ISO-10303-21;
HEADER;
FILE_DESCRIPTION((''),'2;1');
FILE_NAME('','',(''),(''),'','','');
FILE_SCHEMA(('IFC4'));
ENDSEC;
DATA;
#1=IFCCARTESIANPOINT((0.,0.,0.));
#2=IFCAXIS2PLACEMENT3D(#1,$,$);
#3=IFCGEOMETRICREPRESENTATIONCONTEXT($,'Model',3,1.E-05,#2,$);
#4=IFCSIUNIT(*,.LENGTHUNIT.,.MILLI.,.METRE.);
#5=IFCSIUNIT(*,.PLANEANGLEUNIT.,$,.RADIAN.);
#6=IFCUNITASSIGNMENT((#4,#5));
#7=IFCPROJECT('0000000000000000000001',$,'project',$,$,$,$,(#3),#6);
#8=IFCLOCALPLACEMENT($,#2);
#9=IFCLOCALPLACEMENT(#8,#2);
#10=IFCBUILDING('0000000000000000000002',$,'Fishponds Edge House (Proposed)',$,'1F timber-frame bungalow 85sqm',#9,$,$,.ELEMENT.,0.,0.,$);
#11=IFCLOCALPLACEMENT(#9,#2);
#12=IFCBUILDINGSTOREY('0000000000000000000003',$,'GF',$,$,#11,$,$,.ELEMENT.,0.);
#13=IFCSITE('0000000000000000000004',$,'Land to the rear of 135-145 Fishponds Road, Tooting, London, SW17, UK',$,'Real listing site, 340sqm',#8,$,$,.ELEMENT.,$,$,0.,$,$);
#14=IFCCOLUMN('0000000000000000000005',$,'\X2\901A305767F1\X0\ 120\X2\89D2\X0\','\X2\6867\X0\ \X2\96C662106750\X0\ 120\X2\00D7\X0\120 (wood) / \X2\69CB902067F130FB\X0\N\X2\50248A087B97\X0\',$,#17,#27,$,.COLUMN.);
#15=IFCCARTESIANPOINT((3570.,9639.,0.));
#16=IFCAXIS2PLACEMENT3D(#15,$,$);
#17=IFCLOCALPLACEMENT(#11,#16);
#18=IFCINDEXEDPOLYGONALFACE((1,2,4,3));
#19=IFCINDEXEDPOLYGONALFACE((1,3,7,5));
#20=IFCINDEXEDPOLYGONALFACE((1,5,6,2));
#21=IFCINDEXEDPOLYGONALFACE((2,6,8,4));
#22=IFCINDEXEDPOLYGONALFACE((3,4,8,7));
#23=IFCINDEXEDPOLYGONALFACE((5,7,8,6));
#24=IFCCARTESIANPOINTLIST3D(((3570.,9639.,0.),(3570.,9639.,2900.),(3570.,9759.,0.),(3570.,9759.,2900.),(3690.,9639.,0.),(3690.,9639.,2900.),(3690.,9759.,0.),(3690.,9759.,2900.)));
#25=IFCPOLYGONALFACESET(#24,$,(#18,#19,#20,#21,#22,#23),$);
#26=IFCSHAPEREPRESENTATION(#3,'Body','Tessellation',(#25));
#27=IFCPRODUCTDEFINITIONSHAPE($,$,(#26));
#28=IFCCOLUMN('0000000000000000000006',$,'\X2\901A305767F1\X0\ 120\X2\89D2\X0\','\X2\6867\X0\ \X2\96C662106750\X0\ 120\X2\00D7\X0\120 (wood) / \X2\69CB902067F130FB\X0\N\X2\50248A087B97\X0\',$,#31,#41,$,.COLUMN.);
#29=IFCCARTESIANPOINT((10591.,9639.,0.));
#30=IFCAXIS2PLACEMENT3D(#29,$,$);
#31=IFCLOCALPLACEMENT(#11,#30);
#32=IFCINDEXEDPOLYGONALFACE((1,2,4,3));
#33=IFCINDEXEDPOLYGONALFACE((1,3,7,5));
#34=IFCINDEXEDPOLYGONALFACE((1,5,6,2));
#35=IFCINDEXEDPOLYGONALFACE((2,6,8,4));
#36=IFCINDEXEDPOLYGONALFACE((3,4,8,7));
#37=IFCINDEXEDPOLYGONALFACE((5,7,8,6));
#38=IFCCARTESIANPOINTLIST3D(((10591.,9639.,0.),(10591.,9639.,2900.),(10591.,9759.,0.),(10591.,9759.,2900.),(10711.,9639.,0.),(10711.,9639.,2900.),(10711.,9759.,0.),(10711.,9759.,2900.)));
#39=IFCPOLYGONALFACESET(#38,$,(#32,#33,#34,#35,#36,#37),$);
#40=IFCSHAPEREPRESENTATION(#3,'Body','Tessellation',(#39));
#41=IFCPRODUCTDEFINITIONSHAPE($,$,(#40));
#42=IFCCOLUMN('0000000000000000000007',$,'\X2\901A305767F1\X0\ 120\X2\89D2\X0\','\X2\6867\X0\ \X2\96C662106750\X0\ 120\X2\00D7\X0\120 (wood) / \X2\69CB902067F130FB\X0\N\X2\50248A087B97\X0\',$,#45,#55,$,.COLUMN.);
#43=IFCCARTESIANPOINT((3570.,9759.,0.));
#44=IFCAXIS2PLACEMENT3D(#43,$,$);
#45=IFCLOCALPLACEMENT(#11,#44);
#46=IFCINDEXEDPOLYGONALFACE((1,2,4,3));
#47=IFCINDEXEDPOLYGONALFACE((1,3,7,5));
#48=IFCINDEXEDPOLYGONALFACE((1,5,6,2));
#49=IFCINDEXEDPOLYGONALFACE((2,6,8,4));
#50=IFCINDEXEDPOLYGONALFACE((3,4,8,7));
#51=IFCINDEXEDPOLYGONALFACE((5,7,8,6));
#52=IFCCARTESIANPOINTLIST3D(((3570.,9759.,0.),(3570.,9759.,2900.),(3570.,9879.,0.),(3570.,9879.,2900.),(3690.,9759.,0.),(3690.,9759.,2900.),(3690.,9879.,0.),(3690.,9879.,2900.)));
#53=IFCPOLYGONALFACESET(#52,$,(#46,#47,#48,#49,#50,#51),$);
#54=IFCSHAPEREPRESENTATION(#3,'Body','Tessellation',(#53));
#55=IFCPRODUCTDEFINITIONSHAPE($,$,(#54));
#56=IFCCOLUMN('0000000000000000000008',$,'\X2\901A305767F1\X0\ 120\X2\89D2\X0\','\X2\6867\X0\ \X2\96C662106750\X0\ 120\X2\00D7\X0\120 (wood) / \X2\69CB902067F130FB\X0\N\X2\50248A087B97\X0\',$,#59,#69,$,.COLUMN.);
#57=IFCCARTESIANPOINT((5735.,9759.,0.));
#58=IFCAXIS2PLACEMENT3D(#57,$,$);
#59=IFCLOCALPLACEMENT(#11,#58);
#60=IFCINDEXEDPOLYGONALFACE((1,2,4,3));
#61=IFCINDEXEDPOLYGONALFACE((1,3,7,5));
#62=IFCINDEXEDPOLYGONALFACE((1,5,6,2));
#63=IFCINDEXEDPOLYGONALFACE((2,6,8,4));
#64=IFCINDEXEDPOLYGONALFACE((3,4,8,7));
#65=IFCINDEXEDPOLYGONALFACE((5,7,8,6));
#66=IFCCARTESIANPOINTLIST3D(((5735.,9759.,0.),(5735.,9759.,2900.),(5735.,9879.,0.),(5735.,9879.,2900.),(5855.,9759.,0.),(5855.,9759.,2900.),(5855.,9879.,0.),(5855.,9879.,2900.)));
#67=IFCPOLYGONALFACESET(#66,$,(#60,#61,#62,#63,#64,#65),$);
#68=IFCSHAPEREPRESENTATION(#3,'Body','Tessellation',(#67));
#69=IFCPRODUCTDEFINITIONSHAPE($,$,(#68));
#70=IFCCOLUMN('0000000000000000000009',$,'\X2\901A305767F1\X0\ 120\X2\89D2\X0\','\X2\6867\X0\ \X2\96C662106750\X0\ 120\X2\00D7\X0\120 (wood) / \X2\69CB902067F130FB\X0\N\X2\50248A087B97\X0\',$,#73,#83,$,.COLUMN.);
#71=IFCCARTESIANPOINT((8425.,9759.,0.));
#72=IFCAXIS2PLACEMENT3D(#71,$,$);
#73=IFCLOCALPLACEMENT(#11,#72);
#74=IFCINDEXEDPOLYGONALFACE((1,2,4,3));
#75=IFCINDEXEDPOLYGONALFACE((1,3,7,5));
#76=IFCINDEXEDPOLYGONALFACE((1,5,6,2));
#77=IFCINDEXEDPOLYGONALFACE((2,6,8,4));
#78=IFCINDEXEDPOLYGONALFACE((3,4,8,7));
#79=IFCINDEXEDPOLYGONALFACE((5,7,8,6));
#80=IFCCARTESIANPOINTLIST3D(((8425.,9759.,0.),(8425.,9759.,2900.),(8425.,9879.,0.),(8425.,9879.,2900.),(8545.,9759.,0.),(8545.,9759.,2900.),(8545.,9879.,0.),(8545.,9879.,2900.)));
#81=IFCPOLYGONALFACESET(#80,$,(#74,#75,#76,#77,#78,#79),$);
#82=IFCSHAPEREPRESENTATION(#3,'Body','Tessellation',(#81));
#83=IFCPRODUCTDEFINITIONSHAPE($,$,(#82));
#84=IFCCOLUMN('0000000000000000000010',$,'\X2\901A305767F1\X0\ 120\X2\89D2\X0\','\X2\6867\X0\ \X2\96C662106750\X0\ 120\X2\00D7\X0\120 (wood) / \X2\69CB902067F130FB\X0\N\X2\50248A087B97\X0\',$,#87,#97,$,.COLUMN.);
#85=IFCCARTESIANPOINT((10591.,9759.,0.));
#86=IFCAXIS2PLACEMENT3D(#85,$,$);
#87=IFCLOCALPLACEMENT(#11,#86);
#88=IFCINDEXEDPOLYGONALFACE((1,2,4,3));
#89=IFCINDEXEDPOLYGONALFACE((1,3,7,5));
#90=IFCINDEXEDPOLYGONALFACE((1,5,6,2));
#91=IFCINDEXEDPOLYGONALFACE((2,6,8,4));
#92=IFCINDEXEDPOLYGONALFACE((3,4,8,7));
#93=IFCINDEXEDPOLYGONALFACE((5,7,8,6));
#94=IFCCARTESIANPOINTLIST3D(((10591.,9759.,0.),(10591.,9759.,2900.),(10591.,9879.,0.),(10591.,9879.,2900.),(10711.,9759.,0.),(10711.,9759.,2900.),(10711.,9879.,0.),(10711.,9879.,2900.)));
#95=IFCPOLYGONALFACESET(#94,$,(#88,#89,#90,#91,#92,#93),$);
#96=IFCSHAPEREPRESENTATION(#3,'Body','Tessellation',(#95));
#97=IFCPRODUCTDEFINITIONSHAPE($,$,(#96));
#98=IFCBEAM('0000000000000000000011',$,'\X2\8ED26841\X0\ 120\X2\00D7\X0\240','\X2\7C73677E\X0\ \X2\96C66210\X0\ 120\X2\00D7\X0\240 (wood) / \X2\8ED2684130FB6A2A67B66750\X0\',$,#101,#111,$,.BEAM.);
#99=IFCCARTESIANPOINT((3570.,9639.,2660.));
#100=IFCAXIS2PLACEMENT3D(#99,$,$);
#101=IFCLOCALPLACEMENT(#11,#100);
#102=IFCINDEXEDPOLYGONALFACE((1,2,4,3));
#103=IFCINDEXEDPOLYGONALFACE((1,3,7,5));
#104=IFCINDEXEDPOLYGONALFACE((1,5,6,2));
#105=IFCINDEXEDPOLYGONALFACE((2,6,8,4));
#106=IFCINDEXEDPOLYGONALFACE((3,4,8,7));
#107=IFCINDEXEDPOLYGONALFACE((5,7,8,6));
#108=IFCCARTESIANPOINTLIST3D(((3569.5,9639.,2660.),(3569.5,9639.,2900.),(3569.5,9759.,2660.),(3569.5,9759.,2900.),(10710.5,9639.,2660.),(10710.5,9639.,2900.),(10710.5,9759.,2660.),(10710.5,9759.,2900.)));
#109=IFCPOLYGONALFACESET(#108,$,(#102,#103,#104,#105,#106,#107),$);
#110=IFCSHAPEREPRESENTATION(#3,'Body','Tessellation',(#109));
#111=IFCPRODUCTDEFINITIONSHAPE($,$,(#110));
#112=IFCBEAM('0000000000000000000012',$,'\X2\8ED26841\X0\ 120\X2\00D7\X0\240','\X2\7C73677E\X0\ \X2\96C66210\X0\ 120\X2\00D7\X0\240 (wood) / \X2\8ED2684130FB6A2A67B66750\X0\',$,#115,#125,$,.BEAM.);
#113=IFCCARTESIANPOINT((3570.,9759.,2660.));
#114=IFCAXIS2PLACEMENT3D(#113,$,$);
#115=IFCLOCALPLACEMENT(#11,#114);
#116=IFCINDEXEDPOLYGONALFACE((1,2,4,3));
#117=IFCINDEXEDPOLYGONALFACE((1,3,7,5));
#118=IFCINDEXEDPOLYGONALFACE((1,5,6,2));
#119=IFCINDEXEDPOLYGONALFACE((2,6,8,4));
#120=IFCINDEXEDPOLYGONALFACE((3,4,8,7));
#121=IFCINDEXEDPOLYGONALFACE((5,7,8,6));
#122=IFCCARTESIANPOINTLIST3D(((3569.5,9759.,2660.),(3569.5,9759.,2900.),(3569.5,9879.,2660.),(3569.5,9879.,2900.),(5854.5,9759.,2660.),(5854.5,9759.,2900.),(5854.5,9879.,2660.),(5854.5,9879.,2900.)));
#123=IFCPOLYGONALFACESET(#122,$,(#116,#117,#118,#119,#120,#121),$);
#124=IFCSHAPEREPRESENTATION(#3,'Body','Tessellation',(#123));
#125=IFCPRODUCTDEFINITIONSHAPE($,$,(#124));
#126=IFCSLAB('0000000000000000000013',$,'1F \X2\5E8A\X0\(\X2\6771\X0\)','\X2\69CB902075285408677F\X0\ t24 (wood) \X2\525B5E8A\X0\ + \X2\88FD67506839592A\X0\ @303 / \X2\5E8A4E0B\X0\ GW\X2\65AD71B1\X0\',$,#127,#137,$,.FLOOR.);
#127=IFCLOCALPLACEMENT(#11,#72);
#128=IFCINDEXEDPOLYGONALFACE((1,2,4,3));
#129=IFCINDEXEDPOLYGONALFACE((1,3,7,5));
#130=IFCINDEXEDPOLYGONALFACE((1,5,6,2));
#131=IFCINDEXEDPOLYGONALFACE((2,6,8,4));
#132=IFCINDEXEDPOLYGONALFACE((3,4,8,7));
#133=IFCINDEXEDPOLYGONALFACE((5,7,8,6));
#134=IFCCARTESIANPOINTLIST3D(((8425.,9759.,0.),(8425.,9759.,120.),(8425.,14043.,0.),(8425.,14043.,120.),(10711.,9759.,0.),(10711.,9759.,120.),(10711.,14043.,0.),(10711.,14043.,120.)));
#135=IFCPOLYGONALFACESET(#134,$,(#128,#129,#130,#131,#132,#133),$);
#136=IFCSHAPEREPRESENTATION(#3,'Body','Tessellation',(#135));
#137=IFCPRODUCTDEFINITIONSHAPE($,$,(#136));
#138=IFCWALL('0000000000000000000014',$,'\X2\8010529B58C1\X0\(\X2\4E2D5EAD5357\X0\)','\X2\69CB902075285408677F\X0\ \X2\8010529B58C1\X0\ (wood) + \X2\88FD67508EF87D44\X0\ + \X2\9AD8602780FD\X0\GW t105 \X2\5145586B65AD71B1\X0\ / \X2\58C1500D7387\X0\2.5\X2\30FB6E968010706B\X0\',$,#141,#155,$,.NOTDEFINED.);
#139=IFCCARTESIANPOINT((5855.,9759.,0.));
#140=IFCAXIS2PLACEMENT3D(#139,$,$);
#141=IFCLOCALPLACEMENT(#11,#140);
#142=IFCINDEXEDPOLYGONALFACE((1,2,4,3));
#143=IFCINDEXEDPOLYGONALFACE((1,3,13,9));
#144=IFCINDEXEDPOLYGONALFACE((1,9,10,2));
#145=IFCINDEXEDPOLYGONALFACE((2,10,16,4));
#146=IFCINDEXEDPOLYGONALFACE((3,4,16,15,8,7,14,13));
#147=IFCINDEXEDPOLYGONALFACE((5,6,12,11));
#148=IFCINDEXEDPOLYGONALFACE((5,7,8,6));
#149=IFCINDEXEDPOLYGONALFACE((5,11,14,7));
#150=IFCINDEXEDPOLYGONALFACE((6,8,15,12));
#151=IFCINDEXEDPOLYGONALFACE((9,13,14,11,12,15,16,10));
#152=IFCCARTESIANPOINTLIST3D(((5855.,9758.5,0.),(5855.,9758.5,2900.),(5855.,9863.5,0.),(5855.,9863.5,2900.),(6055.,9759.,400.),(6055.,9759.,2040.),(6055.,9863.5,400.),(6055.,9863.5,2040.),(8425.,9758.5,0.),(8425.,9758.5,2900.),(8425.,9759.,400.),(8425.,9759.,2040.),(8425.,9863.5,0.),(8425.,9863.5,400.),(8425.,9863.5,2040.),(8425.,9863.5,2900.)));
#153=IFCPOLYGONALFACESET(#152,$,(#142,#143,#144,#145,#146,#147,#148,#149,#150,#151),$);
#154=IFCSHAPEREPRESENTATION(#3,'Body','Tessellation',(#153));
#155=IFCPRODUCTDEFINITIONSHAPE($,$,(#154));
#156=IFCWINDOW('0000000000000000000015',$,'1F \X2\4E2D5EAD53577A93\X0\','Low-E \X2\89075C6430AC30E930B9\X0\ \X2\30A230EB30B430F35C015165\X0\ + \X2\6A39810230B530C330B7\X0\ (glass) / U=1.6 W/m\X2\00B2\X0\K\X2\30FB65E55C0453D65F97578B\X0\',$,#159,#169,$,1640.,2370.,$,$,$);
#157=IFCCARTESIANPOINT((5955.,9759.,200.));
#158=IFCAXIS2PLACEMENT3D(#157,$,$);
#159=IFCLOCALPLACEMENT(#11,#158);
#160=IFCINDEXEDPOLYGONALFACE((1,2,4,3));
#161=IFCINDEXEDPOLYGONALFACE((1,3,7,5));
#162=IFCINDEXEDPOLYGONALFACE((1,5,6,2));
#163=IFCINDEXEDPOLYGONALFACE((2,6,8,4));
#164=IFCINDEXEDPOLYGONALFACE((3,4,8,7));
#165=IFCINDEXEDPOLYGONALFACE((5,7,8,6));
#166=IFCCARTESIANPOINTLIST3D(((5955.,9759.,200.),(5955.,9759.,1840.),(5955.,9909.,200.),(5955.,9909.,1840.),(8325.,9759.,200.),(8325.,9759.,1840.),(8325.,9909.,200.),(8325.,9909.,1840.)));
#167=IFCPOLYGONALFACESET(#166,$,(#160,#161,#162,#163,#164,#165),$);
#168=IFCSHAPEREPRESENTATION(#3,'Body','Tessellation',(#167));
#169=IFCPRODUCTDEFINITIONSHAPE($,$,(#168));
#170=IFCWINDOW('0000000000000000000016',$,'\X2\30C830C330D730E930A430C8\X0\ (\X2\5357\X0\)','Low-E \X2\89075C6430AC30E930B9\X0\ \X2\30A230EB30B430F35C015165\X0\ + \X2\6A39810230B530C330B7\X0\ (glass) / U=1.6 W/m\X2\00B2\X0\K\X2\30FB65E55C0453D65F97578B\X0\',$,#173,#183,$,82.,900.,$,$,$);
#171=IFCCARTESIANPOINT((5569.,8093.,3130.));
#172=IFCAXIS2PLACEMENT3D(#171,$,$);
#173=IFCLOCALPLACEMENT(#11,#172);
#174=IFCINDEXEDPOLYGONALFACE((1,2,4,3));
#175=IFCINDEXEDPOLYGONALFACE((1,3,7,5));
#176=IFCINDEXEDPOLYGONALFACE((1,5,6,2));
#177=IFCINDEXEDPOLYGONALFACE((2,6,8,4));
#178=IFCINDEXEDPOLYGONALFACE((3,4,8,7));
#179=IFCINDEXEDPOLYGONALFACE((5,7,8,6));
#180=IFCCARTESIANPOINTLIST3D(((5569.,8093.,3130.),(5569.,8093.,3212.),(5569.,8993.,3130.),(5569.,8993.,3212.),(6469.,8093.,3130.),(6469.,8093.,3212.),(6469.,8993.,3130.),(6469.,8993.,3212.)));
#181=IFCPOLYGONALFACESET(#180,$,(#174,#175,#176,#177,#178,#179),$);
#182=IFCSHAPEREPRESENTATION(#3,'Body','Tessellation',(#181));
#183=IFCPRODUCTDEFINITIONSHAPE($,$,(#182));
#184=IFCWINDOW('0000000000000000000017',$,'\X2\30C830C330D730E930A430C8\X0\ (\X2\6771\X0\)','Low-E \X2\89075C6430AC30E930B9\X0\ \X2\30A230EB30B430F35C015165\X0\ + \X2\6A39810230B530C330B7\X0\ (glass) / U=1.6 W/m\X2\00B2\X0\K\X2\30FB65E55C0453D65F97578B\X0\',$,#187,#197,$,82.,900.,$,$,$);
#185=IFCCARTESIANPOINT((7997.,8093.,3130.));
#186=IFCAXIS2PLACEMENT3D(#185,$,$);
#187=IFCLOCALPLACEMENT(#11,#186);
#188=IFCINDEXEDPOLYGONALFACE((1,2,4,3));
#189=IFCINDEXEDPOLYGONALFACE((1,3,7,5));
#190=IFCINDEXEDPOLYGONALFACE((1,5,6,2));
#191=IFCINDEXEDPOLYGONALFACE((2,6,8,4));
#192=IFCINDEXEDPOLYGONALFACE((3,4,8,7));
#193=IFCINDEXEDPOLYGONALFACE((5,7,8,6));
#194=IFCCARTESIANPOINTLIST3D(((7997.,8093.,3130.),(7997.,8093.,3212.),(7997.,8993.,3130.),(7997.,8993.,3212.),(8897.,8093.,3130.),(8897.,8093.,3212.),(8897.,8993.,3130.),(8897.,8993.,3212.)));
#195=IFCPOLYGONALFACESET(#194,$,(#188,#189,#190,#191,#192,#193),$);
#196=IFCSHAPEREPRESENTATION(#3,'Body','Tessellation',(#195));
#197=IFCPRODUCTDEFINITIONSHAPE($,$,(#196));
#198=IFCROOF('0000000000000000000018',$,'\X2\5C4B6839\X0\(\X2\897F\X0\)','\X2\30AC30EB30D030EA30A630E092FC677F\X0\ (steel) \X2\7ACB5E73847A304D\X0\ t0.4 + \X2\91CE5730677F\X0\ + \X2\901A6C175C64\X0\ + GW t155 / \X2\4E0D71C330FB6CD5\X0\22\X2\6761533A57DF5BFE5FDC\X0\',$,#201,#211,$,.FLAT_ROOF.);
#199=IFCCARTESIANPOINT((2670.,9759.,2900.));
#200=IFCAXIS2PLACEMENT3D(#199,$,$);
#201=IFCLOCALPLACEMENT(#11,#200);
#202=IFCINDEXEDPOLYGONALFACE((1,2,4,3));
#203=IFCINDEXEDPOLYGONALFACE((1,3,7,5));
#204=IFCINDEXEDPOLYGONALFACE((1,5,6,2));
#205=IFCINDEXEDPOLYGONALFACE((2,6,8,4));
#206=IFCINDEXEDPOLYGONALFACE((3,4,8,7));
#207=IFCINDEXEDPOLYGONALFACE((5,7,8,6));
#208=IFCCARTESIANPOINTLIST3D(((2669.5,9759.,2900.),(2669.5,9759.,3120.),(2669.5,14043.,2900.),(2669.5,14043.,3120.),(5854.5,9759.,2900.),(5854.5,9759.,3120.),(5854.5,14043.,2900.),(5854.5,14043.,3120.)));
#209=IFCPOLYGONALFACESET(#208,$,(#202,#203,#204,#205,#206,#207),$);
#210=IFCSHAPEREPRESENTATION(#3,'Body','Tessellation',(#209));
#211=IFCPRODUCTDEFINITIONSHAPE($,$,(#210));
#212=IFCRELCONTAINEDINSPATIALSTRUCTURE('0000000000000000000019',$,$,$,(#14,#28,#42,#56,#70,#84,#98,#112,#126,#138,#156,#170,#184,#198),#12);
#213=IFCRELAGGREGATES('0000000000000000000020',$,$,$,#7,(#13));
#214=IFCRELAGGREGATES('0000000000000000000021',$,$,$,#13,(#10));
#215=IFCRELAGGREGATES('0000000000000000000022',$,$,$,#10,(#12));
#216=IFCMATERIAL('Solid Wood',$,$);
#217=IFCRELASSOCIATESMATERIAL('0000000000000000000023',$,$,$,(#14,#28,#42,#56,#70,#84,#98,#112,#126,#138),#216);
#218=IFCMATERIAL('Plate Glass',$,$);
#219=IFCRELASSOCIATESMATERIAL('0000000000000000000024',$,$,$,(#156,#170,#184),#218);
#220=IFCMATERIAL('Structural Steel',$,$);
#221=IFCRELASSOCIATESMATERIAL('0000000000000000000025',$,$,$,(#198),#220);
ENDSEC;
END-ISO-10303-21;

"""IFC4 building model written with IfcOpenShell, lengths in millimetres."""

from ifc_helpers import new_model, si_unit, frame, frame_2d, origin, place, context, project, spatial, rectangle, extrude, material, element, fill, save


model = new_model("IFC4")

# Units and contexts
model_context = context("Model", 3, precision=1e-05, world=origin())
ifc_project = project(units=[si_unit("LENGTHUNIT", "METRE", prefix="MILLI"), si_unit("PLANEANGLEUNIT", "RADIAN")], contexts=[model_context])

# Site, building, storey
site_placement = place(None, origin())
site = spatial("IfcSite", under=ifc_project, at=site_placement, Name="Land to the rear of 135-145 Fishponds Road, Tooting, London, SW17, UK", ObjectType="Real listing site, 340sqm", CompositionType="ELEMENT", RefElevation=0.0)
building_placement = place(site_placement, origin())
building = spatial("IfcBuilding", under=site, at=building_placement, Name="Fishponds Edge House (Proposed)", ObjectType="1F timber-frame bungalow 85sqm", CompositionType="ELEMENT", ElevationOfRefHeight=0.0, ElevationOfTerrain=0.0)
storey_placement = place(building_placement, origin())
storey = spatial("IfcBuildingStorey", under=building, at=storey_placement, Name="GF", CompositionType="ELEMENT", Elevation=0.0)

# Columns
ifc_material_1 = material(Name="Solid Wood")
column_1_placement = place(storey_placement, frame((3570.0, 9639.0, 0.0)))
element("IfcColumn", 1, at=column_1_placement, inside=storey, material=ifc_material_1, Name="通し柱 120角", Description="桧 集成材 120×120 (wood) / 構造柱・N値計算", PredefinedType="COLUMN", context=model_context, shape_type="SweptSolid", body=[
    extrude(rectangle(XDim=120.0, YDim=120.0, at=frame_2d((60.0, 60.0))), frame((3570.0, 9639.0, 0.0)), (0.0, 0.0, 1.0), 2900.0),
])
column_2_placement = place(storey_placement, frame((10591.0, 9639.0, 0.0)))
element("IfcColumn", 2, at=column_2_placement, inside=storey, material=ifc_material_1, Name="通し柱 120角", Description="桧 集成材 120×120 (wood) / 構造柱・N値計算", PredefinedType="COLUMN", context=model_context, shape_type="SweptSolid", body=[
    extrude(rectangle(XDim=120.0, YDim=120.0, at=frame_2d((60.0, 60.0))), frame((10591.0, 9639.0, 0.0)), (0.0, 0.0, 1.0), 2900.0),
])
column_3_placement = place(storey_placement, frame((3570.0, 9759.0, 0.0)))
element("IfcColumn", 3, at=column_3_placement, inside=storey, material=ifc_material_1, Name="通し柱 120角", Description="桧 集成材 120×120 (wood) / 構造柱・N値計算", PredefinedType="COLUMN", context=model_context, shape_type="SweptSolid", body=[
    extrude(rectangle(XDim=120.0, YDim=120.0, at=frame_2d((60.0, 60.0))), frame((3570.0, 9759.0, 0.0)), (0.0, 0.0, 1.0), 2900.0),
])
column_4_placement = place(storey_placement, frame((5735.0, 9759.0, 0.0)))
element("IfcColumn", 4, at=column_4_placement, inside=storey, material=ifc_material_1, Name="通し柱 120角", Description="桧 集成材 120×120 (wood) / 構造柱・N値計算", PredefinedType="COLUMN", context=model_context, shape_type="SweptSolid", body=[
    extrude(rectangle(XDim=120.0, YDim=120.0, at=frame_2d((60.0, 60.0))), frame((5735.0, 9759.0, 0.0)), (0.0, 0.0, 1.0), 2900.0),
])
column_5_placement = place(storey_placement, frame((8425.0, 9759.0, 0.0)))
element("IfcColumn", 5, at=column_5_placement, inside=storey, material=ifc_material_1, Name="通し柱 120角", Description="桧 集成材 120×120 (wood) / 構造柱・N値計算", PredefinedType="COLUMN", context=model_context, shape_type="SweptSolid", body=[
    extrude(rectangle(XDim=120.0, YDim=120.0, at=frame_2d((60.0, 60.0))), frame((8425.0, 9759.0, 0.0)), (0.0, 0.0, 1.0), 2900.0),
])
column_6_placement = place(storey_placement, frame((10591.0, 9759.0, 0.0)))
element("IfcColumn", 6, at=column_6_placement, inside=storey, material=ifc_material_1, Name="通し柱 120角", Description="桧 集成材 120×120 (wood) / 構造柱・N値計算", PredefinedType="COLUMN", context=model_context, shape_type="SweptSolid", body=[
    extrude(rectangle(XDim=120.0, YDim=120.0, at=frame_2d((60.0, 60.0))), frame((10591.0, 9759.0, 0.0)), (0.0, 0.0, 1.0), 2900.0),
])

# Beams
beam_1_placement = place(storey_placement, frame((3570.0, 9639.0, 2660.0)))
element("IfcBeam", 7, at=beam_1_placement, inside=storey, material=ifc_material_1, Name="軒桁 120×240", Description="米松 集成 120×240 (wood) / 軒桁・横架材", PredefinedType="BEAM", context=model_context, shape_type="SweptSolid", body=[
    extrude(rectangle(XDim=7141.0, YDim=120.0, at=frame_2d((3570.0, 60.0))), frame((3570.0, 9639.0, 2660.0)), (0.0, 0.0, 1.0), 240.0),
])
beam_2_placement = place(storey_placement, frame((3570.0, 9759.0, 2660.0)))
element("IfcBeam", 8, at=beam_2_placement, inside=storey, material=ifc_material_1, Name="軒桁 120×240", Description="米松 集成 120×240 (wood) / 軒桁・横架材", PredefinedType="BEAM", context=model_context, shape_type="SweptSolid", body=[
    extrude(rectangle(XDim=2285.0, YDim=120.0, at=frame_2d((1142.0, 60.0))), frame((3570.0, 9759.0, 2660.0)), (0.0, 0.0, 1.0), 240.0),
])

# Slab
slab_1_placement = place(storey_placement, frame((8425.0, 9759.0, 0.0)))
element("IfcSlab", 9, at=slab_1_placement, inside=storey, material=ifc_material_1, Name="1F 床(東)", Description="構造用合板 t24 (wood) 剛床 + 製材根太 @303 / 床下 GW断熱", PredefinedType="FLOOR", context=model_context, shape_type="SweptSolid", body=[
    extrude(rectangle(XDim=2286.0, YDim=4284.0, at=frame_2d((1143.0, 2142.0))), frame((8425.0, 9759.0, 0.0)), (0.0, 0.0, 1.0), 120.0),
])

# Wall, opening, window
wall_1_placement = place(storey_placement, frame((5855.0, 9759.0, 0.0)))
wall_1 = element("IfcWall", 10, at=wall_1_placement, inside=storey, material=ifc_material_1, Name="耐力壁(中庭南)", Description="構造用合板 耐力壁 (wood) + 製材軸組 + 高性能GW t105 充填断熱 / 壁倍率2.5・準耐火", PredefinedType="NOTDEFINED", context=model_context, shape_type="SweptSolid", body=[
    extrude(rectangle(XDim=2570.0, YDim=105.0, at=frame_2d((1285.0, 52.0))), frame((5855.0, 9759.0, 0.0)), (0.0, 0.0, 1.0), 2900.0),
])
opening_placement = place(storey_placement, frame((5955.0, 9759.0, 200.0)))
opening = element("IfcOpeningElement", 11, at=opening_placement, cuts=wall_1, PredefinedType="NOTDEFINED", context=model_context, shape_type="SweptSolid", body=[
    extrude(rectangle(XDim=2370.0, YDim=150.0, at=frame_2d((1185.0, 75.0))), frame((5955.0, 9759.0, 200.0)), (0.0, 0.0, 1.0), 1640.0),
])
ifc_material_2 = material(Name="Plate Glass")
window_1_placement = place(storey_placement, frame((5955.0, 9759.0, 200.0)))
window_1 = element("IfcWindow", 12, at=window_1_placement, inside=storey, material=ifc_material_2, Name="1F 中庭南窓", Description="Low-E 複層ガラス アルゴン封入 + 樹脂サッシ (glass) / U=1.6 W/m²K・日射取得型", OverallHeight=1640.0, OverallWidth=2370.0, context=model_context, shape_type="SweptSolid", body=[
    extrude(rectangle(XDim=2370.0, YDim=150.0, at=frame_2d((1185.0, 75.0))), frame((5955.0, 9759.0, 200.0)), (0.0, 0.0, 1.0), 1640.0),
])
fill(opening, window_1)

# Windows
window_2_placement = place(storey_placement, frame((5569.0, 8093.0, 3130.0)))
element("IfcWindow", 13, at=window_2_placement, inside=storey, material=ifc_material_2, Name="トップライト (南)", Description="Low-E 複層ガラス アルゴン封入 + 樹脂サッシ (glass) / U=1.6 W/m²K・日射取得型", OverallHeight=82.0, OverallWidth=900.0, context=model_context, shape_type="SweptSolid", body=[
    extrude(rectangle(XDim=900.0, YDim=900.0, at=frame_2d((450.0, 450.0))), frame((5569.0, 8093.0, 3130.0)), (0.0, 0.0, 1.0), 82.0),
])
window_3_placement = place(storey_placement, frame((7997.0, 8093.0, 3130.0)))
element("IfcWindow", 14, at=window_3_placement, inside=storey, material=ifc_material_2, Name="トップライト (東)", Description="Low-E 複層ガラス アルゴン封入 + 樹脂サッシ (glass) / U=1.6 W/m²K・日射取得型", OverallHeight=82.0, OverallWidth=900.0, context=model_context, shape_type="SweptSolid", body=[
    extrude(rectangle(XDim=900.0, YDim=900.0, at=frame_2d((450.0, 450.0))), frame((7997.0, 8093.0, 3130.0)), (0.0, 0.0, 1.0), 82.0),
])

# Roof
ifc_material_3 = material(Name="Structural Steel")
roof_1_placement = place(storey_placement, frame((2670.0, 9759.0, 2900.0)))
element("IfcRoof", 15, at=roof_1_placement, inside=storey, material=ifc_material_3, Name="屋根(西)", Description="ガルバリウム鋼板 (steel) 立平葺き t0.4 + 野地板 + 通気層 + GW t155 / 不燃・法22条区域対応", PredefinedType="FLAT_ROOF", context=model_context, shape_type="SweptSolid", body=[
    extrude(rectangle(XDim=3185.0, YDim=4284.0, at=frame_2d((1592.0, 2142.0))), frame((2670.0, 9759.0, 2900.0)), (0.0, 0.0, 1.0), 220.0),
])

save(model, "model.ifc")
